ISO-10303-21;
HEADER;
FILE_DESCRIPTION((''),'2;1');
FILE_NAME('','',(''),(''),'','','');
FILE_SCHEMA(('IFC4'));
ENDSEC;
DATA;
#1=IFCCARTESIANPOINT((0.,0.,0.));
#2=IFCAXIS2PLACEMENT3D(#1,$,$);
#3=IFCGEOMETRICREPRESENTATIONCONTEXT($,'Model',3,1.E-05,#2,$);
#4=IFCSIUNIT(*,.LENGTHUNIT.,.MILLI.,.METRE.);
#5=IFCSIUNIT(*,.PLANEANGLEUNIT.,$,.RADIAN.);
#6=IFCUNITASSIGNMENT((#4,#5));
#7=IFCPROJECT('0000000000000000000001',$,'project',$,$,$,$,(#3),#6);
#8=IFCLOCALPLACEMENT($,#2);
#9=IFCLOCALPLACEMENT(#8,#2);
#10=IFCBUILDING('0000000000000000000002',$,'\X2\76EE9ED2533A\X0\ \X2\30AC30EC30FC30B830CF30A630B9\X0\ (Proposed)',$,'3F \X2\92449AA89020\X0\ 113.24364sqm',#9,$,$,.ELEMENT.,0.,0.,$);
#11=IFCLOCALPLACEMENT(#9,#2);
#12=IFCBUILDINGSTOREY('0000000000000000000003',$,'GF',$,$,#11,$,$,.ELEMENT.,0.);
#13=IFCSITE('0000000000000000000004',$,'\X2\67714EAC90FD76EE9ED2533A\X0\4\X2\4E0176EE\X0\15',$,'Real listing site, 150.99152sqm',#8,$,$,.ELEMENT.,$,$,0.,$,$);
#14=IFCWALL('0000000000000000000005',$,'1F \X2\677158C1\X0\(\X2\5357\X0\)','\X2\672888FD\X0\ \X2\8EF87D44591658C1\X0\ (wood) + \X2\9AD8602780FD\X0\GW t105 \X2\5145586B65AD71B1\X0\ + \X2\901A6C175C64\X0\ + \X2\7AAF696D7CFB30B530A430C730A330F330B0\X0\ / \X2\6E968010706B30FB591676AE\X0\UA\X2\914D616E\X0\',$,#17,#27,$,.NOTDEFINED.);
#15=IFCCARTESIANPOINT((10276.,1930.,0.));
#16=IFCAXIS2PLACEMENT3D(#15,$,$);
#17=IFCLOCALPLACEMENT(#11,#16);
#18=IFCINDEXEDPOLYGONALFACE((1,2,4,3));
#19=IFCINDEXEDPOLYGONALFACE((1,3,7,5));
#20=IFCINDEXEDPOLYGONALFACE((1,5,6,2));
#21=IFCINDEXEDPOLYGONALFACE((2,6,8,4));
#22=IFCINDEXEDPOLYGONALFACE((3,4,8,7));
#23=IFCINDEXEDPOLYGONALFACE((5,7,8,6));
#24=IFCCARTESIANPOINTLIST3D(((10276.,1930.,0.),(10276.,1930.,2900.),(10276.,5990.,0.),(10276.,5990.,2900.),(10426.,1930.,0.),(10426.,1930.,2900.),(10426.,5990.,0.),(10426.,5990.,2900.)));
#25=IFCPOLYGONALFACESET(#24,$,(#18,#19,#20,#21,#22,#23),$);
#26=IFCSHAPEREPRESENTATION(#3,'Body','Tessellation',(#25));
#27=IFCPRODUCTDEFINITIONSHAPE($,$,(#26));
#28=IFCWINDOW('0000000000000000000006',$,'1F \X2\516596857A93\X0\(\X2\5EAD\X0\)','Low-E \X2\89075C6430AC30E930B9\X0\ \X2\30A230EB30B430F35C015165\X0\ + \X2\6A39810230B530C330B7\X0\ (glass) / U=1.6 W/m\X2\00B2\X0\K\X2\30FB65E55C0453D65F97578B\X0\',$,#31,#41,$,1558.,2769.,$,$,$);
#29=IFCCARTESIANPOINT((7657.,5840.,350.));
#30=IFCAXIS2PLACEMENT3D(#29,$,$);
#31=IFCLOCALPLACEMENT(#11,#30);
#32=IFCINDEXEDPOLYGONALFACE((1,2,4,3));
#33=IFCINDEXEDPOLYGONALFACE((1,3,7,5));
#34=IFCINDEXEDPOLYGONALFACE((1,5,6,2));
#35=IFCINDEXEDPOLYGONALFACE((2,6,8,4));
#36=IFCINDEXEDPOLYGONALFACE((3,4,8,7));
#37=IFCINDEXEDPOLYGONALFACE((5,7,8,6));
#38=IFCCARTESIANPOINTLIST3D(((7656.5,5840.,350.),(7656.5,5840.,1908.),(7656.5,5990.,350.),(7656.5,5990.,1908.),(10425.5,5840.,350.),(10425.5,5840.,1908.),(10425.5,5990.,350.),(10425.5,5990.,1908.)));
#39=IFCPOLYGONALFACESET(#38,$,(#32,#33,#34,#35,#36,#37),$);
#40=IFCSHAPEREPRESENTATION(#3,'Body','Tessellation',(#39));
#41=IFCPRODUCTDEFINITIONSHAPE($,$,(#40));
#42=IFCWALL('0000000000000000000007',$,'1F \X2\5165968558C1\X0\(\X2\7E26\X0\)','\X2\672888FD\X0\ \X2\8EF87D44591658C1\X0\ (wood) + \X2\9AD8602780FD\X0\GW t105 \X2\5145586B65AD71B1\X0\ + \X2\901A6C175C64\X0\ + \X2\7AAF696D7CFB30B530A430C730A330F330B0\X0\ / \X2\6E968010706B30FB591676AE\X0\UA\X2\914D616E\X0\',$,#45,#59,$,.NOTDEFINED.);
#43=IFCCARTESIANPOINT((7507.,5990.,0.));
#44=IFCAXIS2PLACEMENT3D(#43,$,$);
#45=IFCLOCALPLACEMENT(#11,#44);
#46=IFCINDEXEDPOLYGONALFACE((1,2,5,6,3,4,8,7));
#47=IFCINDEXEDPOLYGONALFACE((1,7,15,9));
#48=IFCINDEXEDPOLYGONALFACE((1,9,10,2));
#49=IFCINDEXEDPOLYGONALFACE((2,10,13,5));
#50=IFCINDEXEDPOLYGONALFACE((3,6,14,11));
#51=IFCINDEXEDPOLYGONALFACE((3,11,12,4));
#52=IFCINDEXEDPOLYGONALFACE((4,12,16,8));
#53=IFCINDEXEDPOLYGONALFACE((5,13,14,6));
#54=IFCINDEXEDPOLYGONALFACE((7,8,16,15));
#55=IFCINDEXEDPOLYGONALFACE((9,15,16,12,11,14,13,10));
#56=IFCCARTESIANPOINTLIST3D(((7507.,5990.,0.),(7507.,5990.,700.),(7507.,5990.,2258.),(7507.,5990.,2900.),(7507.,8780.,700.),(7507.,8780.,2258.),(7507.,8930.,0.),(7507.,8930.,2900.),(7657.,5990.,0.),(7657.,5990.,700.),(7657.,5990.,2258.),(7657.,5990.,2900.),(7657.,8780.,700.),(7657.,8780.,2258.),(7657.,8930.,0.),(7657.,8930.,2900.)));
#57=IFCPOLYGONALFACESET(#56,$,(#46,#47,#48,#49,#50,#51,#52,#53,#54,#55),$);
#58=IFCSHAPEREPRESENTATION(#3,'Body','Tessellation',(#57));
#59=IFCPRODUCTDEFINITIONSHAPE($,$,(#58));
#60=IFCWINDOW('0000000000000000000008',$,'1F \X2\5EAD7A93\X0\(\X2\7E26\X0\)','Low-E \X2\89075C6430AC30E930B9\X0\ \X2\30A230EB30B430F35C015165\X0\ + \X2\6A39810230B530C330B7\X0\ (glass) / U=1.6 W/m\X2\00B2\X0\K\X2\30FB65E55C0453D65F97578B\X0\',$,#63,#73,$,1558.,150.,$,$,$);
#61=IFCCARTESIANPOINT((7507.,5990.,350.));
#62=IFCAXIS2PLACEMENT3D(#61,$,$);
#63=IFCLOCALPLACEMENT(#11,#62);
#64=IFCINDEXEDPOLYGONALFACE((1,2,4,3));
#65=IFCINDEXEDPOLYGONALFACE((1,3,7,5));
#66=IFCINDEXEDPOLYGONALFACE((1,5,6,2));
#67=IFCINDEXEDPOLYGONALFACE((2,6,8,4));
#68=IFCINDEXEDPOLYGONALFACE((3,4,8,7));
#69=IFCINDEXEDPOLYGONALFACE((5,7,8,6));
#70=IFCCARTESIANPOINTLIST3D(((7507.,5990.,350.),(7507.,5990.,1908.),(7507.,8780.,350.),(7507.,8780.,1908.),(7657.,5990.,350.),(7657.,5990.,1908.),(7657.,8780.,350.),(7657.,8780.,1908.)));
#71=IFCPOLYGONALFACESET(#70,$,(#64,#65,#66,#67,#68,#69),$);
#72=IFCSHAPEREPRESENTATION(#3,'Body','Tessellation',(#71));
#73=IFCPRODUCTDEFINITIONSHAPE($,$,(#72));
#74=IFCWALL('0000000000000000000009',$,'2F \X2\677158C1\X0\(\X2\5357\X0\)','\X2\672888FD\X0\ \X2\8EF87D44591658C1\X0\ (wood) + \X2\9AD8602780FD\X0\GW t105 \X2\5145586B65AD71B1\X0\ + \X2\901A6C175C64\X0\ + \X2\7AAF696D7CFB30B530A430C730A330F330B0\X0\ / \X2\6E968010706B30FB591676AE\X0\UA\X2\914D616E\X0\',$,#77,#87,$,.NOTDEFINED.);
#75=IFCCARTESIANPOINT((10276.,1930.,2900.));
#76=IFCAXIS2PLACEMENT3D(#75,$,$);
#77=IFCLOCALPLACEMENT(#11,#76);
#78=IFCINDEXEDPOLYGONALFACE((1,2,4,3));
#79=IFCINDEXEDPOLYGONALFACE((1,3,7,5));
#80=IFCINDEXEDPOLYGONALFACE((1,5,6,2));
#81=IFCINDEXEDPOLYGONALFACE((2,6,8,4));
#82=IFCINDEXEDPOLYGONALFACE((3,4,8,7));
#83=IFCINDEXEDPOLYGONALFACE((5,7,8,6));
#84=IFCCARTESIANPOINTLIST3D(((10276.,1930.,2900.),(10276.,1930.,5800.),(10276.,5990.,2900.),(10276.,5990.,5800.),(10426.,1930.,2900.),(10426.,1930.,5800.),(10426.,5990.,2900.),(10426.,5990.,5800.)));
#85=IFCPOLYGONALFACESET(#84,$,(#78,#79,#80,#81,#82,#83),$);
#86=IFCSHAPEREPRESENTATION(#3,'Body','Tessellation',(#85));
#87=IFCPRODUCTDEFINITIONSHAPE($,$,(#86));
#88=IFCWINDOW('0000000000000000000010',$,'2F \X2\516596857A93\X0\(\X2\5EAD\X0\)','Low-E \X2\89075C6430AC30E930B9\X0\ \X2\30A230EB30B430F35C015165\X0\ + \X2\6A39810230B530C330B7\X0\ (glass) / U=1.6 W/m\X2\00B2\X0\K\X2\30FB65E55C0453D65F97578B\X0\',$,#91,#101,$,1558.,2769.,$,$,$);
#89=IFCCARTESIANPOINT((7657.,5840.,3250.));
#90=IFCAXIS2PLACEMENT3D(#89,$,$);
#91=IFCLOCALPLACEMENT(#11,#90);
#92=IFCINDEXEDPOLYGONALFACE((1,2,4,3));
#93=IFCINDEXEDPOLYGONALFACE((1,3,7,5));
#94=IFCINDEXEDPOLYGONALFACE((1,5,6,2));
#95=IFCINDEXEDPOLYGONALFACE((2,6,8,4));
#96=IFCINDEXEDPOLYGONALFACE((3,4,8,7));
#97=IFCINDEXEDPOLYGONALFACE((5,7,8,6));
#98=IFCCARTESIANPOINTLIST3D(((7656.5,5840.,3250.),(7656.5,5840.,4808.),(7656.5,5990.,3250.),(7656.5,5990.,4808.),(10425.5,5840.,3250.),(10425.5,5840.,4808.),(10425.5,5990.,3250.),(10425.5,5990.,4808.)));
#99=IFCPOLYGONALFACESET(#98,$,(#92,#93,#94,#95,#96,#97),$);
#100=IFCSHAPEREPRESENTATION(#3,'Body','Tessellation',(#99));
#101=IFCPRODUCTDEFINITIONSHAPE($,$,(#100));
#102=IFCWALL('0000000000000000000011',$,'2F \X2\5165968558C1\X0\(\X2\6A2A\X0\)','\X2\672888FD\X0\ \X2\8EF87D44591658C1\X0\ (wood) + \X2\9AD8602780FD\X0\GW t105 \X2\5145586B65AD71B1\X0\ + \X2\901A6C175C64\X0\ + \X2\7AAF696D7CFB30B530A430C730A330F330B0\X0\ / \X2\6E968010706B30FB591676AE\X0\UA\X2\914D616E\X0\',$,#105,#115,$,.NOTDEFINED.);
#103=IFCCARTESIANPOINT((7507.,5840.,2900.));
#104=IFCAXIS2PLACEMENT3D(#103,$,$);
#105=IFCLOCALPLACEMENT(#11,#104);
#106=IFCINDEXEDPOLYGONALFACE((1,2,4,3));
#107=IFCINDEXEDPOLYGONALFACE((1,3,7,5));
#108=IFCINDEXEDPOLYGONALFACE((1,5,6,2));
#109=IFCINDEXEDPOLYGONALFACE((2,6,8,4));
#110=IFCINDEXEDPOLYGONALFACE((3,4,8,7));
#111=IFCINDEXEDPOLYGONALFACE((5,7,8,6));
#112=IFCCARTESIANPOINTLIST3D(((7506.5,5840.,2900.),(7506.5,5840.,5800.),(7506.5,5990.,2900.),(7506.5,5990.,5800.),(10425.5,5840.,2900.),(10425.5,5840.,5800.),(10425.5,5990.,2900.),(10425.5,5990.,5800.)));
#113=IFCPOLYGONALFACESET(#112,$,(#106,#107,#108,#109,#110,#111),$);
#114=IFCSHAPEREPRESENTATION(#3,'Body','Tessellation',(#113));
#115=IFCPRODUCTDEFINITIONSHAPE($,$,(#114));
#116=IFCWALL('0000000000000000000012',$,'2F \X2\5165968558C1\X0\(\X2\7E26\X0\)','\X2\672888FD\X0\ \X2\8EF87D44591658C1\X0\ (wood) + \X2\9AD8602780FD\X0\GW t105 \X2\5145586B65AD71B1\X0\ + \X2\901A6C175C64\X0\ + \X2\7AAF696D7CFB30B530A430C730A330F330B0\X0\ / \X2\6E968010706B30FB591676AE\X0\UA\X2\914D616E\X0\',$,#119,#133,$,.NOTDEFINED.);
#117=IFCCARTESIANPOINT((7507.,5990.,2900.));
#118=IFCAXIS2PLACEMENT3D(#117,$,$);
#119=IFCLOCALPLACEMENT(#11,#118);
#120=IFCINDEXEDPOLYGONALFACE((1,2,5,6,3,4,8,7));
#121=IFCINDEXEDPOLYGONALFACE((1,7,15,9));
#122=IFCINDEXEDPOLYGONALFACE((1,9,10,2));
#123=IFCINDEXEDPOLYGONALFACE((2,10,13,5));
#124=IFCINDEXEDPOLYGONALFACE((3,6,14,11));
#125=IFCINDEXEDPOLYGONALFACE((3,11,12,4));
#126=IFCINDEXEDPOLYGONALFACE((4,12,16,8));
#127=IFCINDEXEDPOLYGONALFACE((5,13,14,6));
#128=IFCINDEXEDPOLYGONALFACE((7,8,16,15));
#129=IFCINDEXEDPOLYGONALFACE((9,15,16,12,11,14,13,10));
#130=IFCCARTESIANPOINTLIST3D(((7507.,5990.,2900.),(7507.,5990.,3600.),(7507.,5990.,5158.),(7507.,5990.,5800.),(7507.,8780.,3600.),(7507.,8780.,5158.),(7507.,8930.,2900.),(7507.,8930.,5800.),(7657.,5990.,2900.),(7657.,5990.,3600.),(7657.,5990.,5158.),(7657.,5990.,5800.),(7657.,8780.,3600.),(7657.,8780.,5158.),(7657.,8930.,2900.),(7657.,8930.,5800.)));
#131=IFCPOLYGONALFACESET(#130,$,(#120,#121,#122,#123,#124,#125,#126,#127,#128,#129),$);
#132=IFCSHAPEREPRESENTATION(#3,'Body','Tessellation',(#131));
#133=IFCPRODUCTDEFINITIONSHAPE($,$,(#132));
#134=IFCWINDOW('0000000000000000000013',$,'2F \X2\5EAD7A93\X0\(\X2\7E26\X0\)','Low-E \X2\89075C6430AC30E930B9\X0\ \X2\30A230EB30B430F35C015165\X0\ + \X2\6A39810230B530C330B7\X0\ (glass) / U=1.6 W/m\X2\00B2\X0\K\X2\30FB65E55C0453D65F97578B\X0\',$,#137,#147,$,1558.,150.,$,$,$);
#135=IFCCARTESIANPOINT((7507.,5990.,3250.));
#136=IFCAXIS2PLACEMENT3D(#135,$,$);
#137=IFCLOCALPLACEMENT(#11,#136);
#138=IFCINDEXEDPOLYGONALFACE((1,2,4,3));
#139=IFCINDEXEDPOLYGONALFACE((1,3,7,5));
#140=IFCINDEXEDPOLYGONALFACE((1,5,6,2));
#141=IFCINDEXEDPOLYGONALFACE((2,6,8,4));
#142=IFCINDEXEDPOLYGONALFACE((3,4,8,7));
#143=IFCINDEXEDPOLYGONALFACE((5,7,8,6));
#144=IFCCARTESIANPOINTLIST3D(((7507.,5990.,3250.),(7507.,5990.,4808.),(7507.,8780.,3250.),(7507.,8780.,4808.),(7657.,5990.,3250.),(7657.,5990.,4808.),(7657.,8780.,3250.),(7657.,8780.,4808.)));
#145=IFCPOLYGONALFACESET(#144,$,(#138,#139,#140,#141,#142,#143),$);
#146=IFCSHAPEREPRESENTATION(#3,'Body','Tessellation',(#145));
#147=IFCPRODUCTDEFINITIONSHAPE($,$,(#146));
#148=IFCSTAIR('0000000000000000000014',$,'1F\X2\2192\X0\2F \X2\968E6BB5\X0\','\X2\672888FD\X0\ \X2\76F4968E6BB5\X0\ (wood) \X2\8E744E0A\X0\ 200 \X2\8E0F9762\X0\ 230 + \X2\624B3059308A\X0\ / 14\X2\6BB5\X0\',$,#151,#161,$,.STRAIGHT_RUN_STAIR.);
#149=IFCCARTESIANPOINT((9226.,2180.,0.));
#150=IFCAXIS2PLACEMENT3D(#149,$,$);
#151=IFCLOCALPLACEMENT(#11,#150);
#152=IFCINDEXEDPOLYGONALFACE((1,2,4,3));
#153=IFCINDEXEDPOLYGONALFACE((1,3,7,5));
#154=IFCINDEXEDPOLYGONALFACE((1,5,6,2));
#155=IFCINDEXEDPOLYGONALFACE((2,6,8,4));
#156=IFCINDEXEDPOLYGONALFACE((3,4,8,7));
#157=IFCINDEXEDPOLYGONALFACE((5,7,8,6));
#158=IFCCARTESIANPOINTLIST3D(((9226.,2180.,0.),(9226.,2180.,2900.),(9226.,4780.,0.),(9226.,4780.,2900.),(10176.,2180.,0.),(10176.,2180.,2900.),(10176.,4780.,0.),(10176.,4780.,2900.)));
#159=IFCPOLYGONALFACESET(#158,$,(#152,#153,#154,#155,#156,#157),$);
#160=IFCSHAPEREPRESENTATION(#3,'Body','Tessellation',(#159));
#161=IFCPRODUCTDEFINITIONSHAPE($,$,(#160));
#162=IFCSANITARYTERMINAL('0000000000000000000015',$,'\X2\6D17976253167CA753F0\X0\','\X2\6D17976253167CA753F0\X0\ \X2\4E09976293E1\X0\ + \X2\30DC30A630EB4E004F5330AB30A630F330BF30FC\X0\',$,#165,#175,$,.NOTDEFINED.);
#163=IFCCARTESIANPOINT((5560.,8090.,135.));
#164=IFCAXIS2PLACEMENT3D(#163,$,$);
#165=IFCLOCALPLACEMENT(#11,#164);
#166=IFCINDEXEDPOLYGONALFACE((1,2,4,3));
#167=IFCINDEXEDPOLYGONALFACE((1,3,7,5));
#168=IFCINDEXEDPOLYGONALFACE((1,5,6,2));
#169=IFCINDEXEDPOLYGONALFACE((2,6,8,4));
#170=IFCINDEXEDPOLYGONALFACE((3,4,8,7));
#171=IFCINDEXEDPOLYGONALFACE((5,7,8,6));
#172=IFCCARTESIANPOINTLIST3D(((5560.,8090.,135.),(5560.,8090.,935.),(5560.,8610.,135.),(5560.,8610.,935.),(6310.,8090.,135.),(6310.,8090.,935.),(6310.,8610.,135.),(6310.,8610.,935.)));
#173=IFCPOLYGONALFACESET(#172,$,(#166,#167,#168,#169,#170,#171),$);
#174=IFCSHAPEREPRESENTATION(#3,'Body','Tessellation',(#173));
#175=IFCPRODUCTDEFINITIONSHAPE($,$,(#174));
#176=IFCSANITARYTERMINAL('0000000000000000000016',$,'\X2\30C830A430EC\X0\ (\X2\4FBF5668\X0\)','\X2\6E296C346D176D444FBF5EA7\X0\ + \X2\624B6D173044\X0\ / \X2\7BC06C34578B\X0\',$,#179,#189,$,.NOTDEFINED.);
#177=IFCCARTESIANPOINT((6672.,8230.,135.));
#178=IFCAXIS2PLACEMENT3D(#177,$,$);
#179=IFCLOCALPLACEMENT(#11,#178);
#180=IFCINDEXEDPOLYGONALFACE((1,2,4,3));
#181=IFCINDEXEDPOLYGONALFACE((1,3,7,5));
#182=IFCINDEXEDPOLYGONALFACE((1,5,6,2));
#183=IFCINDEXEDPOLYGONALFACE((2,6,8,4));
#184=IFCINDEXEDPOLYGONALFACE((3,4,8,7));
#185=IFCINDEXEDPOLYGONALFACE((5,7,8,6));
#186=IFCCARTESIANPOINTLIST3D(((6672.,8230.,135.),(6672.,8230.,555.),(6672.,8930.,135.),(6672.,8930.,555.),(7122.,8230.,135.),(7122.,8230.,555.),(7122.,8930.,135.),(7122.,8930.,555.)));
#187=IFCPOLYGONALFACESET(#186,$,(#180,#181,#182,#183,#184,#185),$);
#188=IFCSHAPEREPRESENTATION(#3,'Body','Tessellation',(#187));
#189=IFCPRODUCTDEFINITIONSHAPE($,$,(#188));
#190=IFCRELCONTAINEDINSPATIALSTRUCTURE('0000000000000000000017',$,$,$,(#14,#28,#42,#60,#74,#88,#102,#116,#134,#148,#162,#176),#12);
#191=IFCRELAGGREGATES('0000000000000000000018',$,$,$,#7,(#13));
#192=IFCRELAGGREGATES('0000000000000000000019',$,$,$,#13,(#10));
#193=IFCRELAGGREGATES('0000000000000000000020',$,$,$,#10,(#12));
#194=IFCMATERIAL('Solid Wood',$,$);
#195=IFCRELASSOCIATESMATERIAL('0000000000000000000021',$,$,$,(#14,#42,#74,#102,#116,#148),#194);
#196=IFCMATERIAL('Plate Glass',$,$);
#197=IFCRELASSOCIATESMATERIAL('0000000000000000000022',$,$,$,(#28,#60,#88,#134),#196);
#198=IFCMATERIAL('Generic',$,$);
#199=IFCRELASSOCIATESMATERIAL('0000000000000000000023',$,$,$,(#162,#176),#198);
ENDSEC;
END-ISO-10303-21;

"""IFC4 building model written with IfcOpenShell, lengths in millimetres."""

from ifc_helpers import new_model, si_unit, frame, frame_2d, origin, place, context, project, spatial, rectangle, extrude, material, element, fill, save


model = new_model("IFC4")

# Units and contexts
model_context = context("Model", 3, precision=1e-05, world=origin())
ifc_project = project(units=[si_unit("LENGTHUNIT", "METRE", prefix="MILLI"), si_unit("PLANEANGLEUNIT", "RADIAN")], contexts=[model_context])

# Site, building, storey
site_placement = place(None, origin())
site = spatial("IfcSite", under=ifc_project, at=site_placement, Name="東京都目黒区4丁目15", ObjectType="Real listing site, 150.99152sqm", CompositionType="ELEMENT", RefElevation=0.0)
building_placement = place(site_placement, origin())
building = spatial("IfcBuilding", under=site, at=building_placement, Name="目黒区 ガレージハウス (Proposed)", ObjectType="3F 鉄骨造 113.24364sqm", CompositionType="ELEMENT", ElevationOfRefHeight=0.0, ElevationOfTerrain=0.0)
storey_placement = place(building_placement, origin())
storey = spatial("IfcBuildingStorey", under=building, at=storey_placement, Name="GF", CompositionType="ELEMENT", Elevation=0.0)

# Shared definitions
ifc_material_1 = material(Name="Solid Wood")

# Wall, opening, window
wall_1_placement = place(storey_placement, frame((10276.0, 1930.0, 0.0)))
wall_1 = element("IfcWall", 1, at=wall_1_placement, inside=storey, material=ifc_material_1, Name="1F 東壁(南)", Description="木製 軸組外壁 (wood) + 高性能GW t105 充填断熱 + 通気層 + 窯業系サイディング / 準耐火・外皮UA配慮", PredefinedType="NOTDEFINED", context=model_context, shape_type="SweptSolid", body=[
    extrude(rectangle(XDim=150.0, YDim=4060.0, at=frame_2d((75.0, 2030.0))), frame((10276.0, 1930.0, 0.0)), (0.0, 0.0, 1.0), 2900.0),
])
opening_1_placement = place(storey_placement, frame((7657.0, 5840.0, 350.0)))
opening_1 = element("IfcOpeningElement", 2, at=opening_1_placement, cuts=wall_1, PredefinedType="NOTDEFINED", context=model_context, shape_type="SweptSolid", body=[
    extrude(rectangle(XDim=2769.0, YDim=150.0, at=frame_2d((1384.0, 75.0))), frame((7657.0, 5840.0, 350.0)), (0.0, 0.0, 1.0), 1558.0),
])
ifc_material_2 = material(Name="Plate Glass")
window_1_placement = place(storey_placement, frame((7657.0, 5840.0, 350.0)))
window_1 = element("IfcWindow", 3, at=window_1_placement, inside=storey, material=ifc_material_2, Name="1F 入隅窓(庭)", Description="Low-E 複層ガラス アルゴン封入 + 樹脂サッシ (glass) / U=1.6 W/m²K・日射取得型", OverallHeight=1558.0, OverallWidth=2769.0, context=model_context, shape_type="SweptSolid", body=[
    extrude(rectangle(XDim=2769.0, YDim=150.0, at=frame_2d((1384.0, 75.0))), frame((7657.0, 5840.0, 350.0)), (0.0, 0.0, 1.0), 1558.0),
])
fill(opening_1, window_1)

# Wall, opening, window
wall_2_placement = place(storey_placement, frame((7507.0, 5990.0, 0.0)))
wall_2 = element("IfcWall", 4, at=wall_2_placement, inside=storey, material=ifc_material_1, Name="1F 入隅壁(縦)", Description="木製 軸組外壁 (wood) + 高性能GW t105 充填断熱 + 通気層 + 窯業系サイディング / 準耐火・外皮UA配慮", PredefinedType="NOTDEFINED", context=model_context, shape_type="SweptSolid", body=[
    extrude(rectangle(XDim=150.0, YDim=2940.0, at=frame_2d((75.0, 1470.0))), frame((7507.0, 5990.0, 0.0)), (0.0, 0.0, 1.0), 2900.0),
])
opening_2_placement = place(storey_placement, frame((7507.0, 5990.0, 350.0)))
opening_2 = element("IfcOpeningElement", 5, at=opening_2_placement, cuts=wall_2, PredefinedType="NOTDEFINED", context=model_context, shape_type="SweptSolid", body=[
    extrude(rectangle(XDim=150.0, YDim=2790.0, at=frame_2d((75.0, 1395.0))), frame((7507.0, 5990.0, 350.0)), (0.0, 0.0, 1.0), 1558.0),
])
window_2_placement = place(storey_placement, frame((7507.0, 5990.0, 350.0)))
window_2 = element("IfcWindow", 6, at=window_2_placement, inside=storey, material=ifc_material_2, Name="1F 庭窓(縦)", Description="Low-E 複層ガラス アルゴン封入 + 樹脂サッシ (glass) / U=1.6 W/m²K・日射取得型", OverallHeight=1558.0, OverallWidth=150.0, context=model_context, shape_type="SweptSolid", body=[
    extrude(rectangle(XDim=150.0, YDim=2790.0, at=frame_2d((75.0, 1395.0))), frame((7507.0, 5990.0, 350.0)), (0.0, 0.0, 1.0), 1558.0),
])
fill(opening_2, window_2)

# Wall, opening, window
wall_3_placement = place(storey_placement, frame((10276.0, 1930.0, 2900.0)))
wall_3 = element("IfcWall", 7, at=wall_3_placement, inside=storey, material=ifc_material_1, Name="2F 東壁(南)", Description="木製 軸組外壁 (wood) + 高性能GW t105 充填断熱 + 通気層 + 窯業系サイディング / 準耐火・外皮UA配慮", PredefinedType="NOTDEFINED", context=model_context, shape_type="SweptSolid", body=[
    extrude(rectangle(XDim=150.0, YDim=4060.0, at=frame_2d((75.0, 2030.0))), frame((10276.0, 1930.0, 2900.0)), (0.0, 0.0, 1.0), 2900.0),
])
opening_3_placement = place(storey_placement, frame((7657.0, 5840.0, 3250.0)))
opening_3 = element("IfcOpeningElement", 8, at=opening_3_placement, cuts=wall_3, PredefinedType="NOTDEFINED", context=model_context, shape_type="SweptSolid", body=[
    extrude(rectangle(XDim=2769.0, YDim=150.0, at=frame_2d((1384.0, 75.0))), frame((7657.0, 5840.0, 3250.0)), (0.0, 0.0, 1.0), 1558.0),
])
window_3_placement = place(storey_placement, frame((7657.0, 5840.0, 3250.0)))
window_3 = element("IfcWindow", 9, at=window_3_placement, inside=storey, material=ifc_material_2, Name="2F 入隅窓(庭)", Description="Low-E 複層ガラス アルゴン封入 + 樹脂サッシ (glass) / U=1.6 W/m²K・日射取得型", OverallHeight=1558.0, OverallWidth=2769.0, context=model_context, shape_type="SweptSolid", body=[
    extrude(rectangle(XDim=2769.0, YDim=150.0, at=frame_2d((1384.0, 75.0))), frame((7657.0, 5840.0, 3250.0)), (0.0, 0.0, 1.0), 1558.0),
])
fill(opening_3, window_3)

# Wall
wall_4_placement = place(storey_placement, frame((7507.0, 5840.0, 2900.0)))
element("IfcWall", 10, at=wall_4_placement, inside=storey, material=ifc_material_1, Name="2F 入隅壁(横)", Description="木製 軸組外壁 (wood) + 高性能GW t105 充填断熱 + 通気層 + 窯業系サイディング / 準耐火・外皮UA配慮", PredefinedType="NOTDEFINED", context=model_context, shape_type="SweptSolid", body=[
    extrude(rectangle(XDim=2919.0, YDim=150.0, at=frame_2d((1459.0, 75.0))), frame((7507.0, 5840.0, 2900.0)), (0.0, 0.0, 1.0), 2900.0),
])

# Wall, opening, window
wall_5_placement = place(storey_placement, frame((7507.0, 5990.0, 2900.0)))
wall_5 = element("IfcWall", 11, at=wall_5_placement, inside=storey, material=ifc_material_1, Name="2F 入隅壁(縦)", Description="木製 軸組外壁 (wood) + 高性能GW t105 充填断熱 + 通気層 + 窯業系サイディング / 準耐火・外皮UA配慮", PredefinedType="NOTDEFINED", context=model_context, shape_type="SweptSolid", body=[
    extrude(rectangle(XDim=150.0, YDim=2940.0, at=frame_2d((75.0, 1470.0))), frame((7507.0, 5990.0, 2900.0)), (0.0, 0.0, 1.0), 2900.0),
])
opening_4_placement = place(storey_placement, frame((7507.0, 5990.0, 3250.0)))
opening_4 = element("IfcOpeningElement", 12, at=opening_4_placement, cuts=wall_5, PredefinedType="NOTDEFINED", context=model_context, shape_type="SweptSolid", body=[
    extrude(rectangle(XDim=150.0, YDim=2790.0, at=frame_2d((75.0, 1395.0))), frame((7507.0, 5990.0, 3250.0)), (0.0, 0.0, 1.0), 1558.0),
])
window_4_placement = place(storey_placement, frame((7507.0, 5990.0, 3250.0)))
window_4 = element("IfcWindow", 13, at=window_4_placement, inside=storey, material=ifc_material_2, Name="2F 庭窓(縦)", Description="Low-E 複層ガラス アルゴン封入 + 樹脂サッシ (glass) / U=1.6 W/m²K・日射取得型", OverallHeight=1558.0, OverallWidth=150.0, context=model_context, shape_type="SweptSolid", body=[
    extrude(rectangle(XDim=150.0, YDim=2790.0, at=frame_2d((75.0, 1395.0))), frame((7507.0, 5990.0, 3250.0)), (0.0, 0.0, 1.0), 1558.0),
])
fill(opening_4, window_4)

# Stair
stair_placement = place(storey_placement, frame((9226.0, 2180.0, 0.0)))
element("IfcStair", 14, at=stair_placement, inside=storey, material=ifc_material_1, Name="1F→2F 階段", Description="木製 直階段 (wood) 蹴上 200 踏面 230 + 手すり / 14段", PredefinedType="STRAIGHT_RUN_STAIR", context=model_context, shape_type="SweptSolid", body=[
    extrude(rectangle(XDim=950.0, YDim=2600.0, at=frame_2d((475.0, 1300.0))), frame((9226.0, 2180.0, 0.0)), (0.0, 0.0, 1.0), 2900.0),
])

# Sanitary terminals
ifc_material_3 = material(Name="Generic")
sanitary_terminal_1_placement = place(storey_placement, frame((5560.0, 8090.0, 135.0)))
element("IfcSanitaryTerminal", 15, at=sanitary_terminal_1_placement, inside=storey, material=ifc_material_3, Name="洗面化粧台", Description="洗面化粧台 三面鏡 + ボウル一体カウンター", PredefinedType="NOTDEFINED", context=model_context, shape_type="SweptSolid", body=[
    extrude(rectangle(XDim=750.0, YDim=520.0, at=frame_2d((375.0, 260.0))), frame((5560.0, 8090.0, 135.0)), (0.0, 0.0, 1.0), 800.0),
])
sanitary_terminal_2_placement = place(storey_placement, frame((6672.0, 8230.0, 135.0)))
element("IfcSanitaryTerminal", 16, at=sanitary_terminal_2_placement, inside=storey, material=ifc_material_3, Name="トイレ (便器)", Description="温水洗浄便座 + 手洗い / 節水型", PredefinedType="NOTDEFINED", context=model_context, shape_type="SweptSolid", body=[
    extrude(rectangle(XDim=450.0, YDim=700.0, at=frame_2d((225.0, 350.0))), frame((6672.0, 8230.0, 135.0)), (0.0, 0.0, 1.0), 420.0),
])

save(model, "model.ifc")
